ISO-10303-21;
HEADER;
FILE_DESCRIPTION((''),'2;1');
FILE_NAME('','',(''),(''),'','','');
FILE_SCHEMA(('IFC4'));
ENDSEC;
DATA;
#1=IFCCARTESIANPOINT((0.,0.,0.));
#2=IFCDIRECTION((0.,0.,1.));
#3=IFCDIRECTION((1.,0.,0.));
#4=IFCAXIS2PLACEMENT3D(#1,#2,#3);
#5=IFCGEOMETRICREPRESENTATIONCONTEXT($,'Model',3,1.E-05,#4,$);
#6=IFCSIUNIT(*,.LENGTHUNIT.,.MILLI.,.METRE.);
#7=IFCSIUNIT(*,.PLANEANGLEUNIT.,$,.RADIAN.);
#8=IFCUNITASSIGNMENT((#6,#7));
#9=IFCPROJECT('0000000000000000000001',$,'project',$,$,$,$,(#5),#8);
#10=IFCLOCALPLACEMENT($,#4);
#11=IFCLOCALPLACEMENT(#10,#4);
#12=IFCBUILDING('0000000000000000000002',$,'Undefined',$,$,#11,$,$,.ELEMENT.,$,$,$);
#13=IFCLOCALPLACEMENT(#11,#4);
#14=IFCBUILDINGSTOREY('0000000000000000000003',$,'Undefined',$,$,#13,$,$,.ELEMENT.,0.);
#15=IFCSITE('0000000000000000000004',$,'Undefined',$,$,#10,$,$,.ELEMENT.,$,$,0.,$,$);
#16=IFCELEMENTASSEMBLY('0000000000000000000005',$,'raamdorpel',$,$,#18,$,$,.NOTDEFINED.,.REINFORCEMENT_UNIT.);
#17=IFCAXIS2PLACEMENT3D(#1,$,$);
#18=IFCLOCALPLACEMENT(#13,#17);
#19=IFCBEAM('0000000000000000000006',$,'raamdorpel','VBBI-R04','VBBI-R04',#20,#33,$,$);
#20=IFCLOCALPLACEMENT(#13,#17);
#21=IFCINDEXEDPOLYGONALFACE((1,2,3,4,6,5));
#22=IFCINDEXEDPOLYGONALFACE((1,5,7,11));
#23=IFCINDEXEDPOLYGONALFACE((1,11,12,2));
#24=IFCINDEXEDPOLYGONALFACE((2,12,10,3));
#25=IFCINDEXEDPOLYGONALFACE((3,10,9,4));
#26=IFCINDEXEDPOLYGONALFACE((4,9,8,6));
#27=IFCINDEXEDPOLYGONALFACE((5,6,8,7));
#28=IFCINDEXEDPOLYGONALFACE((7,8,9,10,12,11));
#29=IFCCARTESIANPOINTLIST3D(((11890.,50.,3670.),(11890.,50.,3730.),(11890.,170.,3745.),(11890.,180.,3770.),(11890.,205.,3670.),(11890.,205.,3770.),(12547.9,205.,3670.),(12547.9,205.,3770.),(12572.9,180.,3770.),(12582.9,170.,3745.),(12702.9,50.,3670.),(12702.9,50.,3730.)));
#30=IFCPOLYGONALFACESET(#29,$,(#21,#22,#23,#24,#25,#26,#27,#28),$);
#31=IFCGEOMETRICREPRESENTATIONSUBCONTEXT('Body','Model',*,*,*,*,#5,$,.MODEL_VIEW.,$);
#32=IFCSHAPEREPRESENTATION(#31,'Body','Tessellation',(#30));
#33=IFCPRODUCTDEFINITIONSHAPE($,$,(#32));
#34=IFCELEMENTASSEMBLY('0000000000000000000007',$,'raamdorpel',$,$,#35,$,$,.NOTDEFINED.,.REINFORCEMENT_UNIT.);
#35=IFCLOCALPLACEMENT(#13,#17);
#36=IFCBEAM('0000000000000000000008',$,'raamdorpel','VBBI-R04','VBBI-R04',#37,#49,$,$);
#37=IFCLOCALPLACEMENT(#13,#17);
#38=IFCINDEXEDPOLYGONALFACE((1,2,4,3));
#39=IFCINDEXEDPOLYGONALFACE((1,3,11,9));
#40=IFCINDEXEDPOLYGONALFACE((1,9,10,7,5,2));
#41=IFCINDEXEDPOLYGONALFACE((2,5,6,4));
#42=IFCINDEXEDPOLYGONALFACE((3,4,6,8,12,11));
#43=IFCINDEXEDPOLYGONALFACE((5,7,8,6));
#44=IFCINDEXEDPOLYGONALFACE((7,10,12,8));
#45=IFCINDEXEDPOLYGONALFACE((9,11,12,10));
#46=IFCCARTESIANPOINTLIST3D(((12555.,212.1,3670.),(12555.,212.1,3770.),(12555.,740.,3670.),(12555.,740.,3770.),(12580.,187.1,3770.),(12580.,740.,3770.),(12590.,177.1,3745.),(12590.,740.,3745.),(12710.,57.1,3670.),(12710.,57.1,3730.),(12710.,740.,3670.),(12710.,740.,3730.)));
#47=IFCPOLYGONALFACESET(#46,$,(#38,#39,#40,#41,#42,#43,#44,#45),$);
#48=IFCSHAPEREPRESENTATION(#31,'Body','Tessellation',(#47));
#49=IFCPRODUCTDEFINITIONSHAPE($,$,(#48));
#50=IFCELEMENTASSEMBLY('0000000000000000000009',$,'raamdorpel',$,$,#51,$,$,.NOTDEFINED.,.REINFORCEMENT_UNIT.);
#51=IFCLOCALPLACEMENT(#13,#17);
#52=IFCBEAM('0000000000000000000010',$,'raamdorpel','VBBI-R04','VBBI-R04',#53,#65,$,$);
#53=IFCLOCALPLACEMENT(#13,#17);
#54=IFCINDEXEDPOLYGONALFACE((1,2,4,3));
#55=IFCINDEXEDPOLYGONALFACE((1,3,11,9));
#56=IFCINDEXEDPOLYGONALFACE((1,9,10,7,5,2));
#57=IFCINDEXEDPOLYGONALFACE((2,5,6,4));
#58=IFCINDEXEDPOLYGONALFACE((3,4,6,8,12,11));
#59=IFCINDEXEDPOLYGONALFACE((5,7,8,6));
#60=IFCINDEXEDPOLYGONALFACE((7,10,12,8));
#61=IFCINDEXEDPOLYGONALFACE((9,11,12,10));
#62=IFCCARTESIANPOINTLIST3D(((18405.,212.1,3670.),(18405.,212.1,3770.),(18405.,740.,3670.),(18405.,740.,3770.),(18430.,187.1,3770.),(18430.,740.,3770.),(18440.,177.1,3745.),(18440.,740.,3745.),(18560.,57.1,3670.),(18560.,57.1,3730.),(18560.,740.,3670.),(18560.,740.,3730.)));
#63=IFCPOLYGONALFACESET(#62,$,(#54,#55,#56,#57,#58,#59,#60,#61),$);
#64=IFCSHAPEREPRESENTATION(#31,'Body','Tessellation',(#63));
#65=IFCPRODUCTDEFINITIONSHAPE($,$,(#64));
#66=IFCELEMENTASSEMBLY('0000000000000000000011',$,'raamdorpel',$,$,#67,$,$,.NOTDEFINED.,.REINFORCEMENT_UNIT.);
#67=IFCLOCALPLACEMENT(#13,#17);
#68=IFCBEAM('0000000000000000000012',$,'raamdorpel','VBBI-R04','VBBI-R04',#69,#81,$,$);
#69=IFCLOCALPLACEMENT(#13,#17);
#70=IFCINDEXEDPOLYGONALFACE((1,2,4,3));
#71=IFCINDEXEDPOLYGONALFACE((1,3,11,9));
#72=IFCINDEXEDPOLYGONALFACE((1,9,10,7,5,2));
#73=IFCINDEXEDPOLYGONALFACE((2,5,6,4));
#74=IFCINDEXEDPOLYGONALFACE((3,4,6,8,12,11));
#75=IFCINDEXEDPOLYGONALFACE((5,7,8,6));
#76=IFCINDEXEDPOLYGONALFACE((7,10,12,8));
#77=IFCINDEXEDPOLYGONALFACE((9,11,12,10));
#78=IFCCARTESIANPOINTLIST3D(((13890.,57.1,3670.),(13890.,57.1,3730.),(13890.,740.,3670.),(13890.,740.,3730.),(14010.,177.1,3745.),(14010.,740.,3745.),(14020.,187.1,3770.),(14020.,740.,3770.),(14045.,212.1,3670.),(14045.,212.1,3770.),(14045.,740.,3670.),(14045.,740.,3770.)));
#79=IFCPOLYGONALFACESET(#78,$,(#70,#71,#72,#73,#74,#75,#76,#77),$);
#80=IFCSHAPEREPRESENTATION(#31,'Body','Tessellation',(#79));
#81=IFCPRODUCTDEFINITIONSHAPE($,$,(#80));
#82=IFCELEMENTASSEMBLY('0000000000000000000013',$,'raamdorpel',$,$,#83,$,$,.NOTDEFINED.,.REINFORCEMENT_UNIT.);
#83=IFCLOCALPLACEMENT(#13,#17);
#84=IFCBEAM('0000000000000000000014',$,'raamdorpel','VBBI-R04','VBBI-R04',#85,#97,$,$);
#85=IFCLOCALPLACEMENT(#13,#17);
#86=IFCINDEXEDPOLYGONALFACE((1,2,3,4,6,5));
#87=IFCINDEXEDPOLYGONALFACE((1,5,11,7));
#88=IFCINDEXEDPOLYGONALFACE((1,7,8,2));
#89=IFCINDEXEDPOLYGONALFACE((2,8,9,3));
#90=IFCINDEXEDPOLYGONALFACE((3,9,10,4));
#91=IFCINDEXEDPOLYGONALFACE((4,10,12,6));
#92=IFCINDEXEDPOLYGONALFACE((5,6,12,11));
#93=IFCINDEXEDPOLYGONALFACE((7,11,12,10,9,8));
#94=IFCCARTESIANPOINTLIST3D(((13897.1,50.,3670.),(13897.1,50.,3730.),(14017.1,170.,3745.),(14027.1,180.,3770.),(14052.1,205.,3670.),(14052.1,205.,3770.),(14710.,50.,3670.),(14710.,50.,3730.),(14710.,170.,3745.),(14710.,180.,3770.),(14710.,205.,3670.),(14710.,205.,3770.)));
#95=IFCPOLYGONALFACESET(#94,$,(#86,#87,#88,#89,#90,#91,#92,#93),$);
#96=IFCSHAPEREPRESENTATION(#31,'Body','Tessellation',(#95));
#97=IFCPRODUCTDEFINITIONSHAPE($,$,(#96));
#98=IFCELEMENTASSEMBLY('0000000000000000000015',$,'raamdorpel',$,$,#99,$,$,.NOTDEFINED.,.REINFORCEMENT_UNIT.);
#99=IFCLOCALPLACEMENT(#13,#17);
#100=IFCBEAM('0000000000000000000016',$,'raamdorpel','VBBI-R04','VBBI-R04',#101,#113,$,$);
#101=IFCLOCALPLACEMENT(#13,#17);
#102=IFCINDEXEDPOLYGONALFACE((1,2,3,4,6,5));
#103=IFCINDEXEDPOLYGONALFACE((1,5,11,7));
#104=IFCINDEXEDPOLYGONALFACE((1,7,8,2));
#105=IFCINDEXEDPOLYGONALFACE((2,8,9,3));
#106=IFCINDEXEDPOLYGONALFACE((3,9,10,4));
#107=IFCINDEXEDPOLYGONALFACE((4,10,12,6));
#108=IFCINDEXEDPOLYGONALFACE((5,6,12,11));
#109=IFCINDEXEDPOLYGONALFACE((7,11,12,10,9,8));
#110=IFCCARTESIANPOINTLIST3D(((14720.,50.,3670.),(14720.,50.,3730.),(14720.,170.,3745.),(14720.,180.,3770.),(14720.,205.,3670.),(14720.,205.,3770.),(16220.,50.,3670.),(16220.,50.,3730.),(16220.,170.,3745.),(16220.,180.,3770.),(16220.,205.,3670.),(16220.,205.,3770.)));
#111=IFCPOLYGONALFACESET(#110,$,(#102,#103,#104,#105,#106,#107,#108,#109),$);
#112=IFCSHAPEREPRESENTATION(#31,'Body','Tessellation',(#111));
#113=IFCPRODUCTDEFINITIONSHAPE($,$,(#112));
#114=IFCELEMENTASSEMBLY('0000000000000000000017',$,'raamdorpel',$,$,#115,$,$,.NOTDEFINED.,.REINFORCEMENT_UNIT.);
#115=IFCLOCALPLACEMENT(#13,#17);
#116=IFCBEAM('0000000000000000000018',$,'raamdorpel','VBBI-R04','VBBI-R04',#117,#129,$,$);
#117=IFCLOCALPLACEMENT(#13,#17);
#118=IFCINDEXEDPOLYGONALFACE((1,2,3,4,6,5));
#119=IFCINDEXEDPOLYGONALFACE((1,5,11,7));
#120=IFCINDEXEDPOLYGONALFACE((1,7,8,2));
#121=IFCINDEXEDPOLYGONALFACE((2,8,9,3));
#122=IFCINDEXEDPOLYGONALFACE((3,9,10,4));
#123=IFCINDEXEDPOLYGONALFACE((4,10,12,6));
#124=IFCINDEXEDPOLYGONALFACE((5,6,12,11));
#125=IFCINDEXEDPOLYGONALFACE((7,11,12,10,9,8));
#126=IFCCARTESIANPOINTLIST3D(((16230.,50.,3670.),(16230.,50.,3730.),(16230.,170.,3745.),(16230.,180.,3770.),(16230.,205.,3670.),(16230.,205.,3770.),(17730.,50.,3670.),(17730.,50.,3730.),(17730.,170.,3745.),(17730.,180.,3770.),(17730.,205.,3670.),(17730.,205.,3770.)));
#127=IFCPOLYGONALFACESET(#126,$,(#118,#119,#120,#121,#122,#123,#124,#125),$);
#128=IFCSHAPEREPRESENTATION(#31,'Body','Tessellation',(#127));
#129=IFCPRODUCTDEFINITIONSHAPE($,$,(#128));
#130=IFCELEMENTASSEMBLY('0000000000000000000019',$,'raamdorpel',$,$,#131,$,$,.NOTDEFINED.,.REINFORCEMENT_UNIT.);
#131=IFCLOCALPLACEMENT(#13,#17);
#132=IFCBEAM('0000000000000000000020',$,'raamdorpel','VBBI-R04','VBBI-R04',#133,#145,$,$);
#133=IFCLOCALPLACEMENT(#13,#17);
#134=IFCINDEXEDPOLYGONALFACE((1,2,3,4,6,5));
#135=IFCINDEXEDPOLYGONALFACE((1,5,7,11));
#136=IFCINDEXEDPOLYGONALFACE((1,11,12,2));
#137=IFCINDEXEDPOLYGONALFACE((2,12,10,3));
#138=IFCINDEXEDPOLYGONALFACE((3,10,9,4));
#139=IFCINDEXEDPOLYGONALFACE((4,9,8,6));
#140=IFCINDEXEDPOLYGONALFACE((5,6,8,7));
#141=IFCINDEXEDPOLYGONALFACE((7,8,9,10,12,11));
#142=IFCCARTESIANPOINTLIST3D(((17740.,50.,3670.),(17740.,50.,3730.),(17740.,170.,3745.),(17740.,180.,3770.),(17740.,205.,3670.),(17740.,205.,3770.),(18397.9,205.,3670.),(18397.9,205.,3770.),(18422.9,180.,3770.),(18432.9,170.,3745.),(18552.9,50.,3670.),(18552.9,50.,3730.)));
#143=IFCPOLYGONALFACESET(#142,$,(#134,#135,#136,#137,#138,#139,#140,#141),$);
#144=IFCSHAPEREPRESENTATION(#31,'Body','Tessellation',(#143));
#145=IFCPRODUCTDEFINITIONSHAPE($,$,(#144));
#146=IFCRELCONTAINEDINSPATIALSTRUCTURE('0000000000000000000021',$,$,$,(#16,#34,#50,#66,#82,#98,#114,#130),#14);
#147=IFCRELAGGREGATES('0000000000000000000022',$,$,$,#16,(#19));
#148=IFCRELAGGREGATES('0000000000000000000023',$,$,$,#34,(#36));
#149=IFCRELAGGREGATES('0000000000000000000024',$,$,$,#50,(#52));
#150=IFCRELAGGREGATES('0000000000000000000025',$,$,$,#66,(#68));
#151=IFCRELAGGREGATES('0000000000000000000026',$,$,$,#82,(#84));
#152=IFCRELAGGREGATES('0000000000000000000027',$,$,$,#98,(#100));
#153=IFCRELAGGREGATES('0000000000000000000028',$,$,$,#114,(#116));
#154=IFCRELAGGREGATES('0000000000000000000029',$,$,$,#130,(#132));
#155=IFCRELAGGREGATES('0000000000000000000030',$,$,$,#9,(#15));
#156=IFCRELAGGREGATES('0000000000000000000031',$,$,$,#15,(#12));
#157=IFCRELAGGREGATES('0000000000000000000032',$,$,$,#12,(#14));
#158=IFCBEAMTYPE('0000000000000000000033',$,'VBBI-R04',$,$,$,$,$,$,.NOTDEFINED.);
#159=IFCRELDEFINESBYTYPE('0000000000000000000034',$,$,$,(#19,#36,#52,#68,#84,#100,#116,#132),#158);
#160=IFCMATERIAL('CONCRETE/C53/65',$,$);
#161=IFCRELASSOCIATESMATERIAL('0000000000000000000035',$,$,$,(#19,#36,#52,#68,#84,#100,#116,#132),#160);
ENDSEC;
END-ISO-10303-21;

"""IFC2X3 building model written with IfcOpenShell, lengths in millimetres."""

from ifc_helpers import new_model, si_unit, frame, origin_with_axes, place, context, subcontext, project, spatial, polyline, outline, extrude, clip, halfspace, material, type_object, element, aggregate, save


model = new_model("IFC2X3")

# Units and contexts
model_context = context("Model", 3, precision=1e-05, world=origin_with_axes())
body_context = subcontext(model_context, "Body", "Model", "MODEL_VIEW")
ifc_project = project(units=[si_unit("LENGTHUNIT", "METRE", prefix="MILLI"), si_unit("PLANEANGLEUNIT", "RADIAN")], contexts=[model_context])

# Site, building, storey
site_placement = place(None, origin_with_axes())
site = spatial("IfcSite", under=ifc_project, at=site_placement, Name="Undefined", CompositionType="ELEMENT", RefElevation=0.0)
building_placement = place(site_placement, origin_with_axes())
building = spatial("IfcBuilding", under=site, at=building_placement, Name="Undefined", CompositionType="ELEMENT")
storey_placement = place(building_placement, origin_with_axes())
storey = spatial("IfcBuildingStorey", under=building, at=storey_placement, Name="Undefined", CompositionType="ELEMENT", Elevation=0.0)

# Element assemblies, beams
ifc_material = material(Name="CONCRETE/C53/65")
beam_type_1 = type_object("IfcBeamType", Name="VBBI-R04", PredefinedType="NOTDEFINED")
assembly_1_placement = place(storey_placement, origin_with_axes())
assembly_1 = element("IfcElementAssembly", 1, at=assembly_1_placement, inside=storey, Name="raamdorpel", AssemblyPlace="NOTDEFINED", PredefinedType="REINFORCEMENT_UNIT")
beam_1_placement = place(assembly_1_placement, frame((11890.0, 127.5, 3720.0), z_axis=(-0.000001, -1.0, 0.0), x_axis=(1.0, -0.000001, 0.0)))
beam_1 = element("IfcBeam", 2, at=beam_1_placement, type_object=beam_type_1, material=ifc_material, Name="raamdorpel", Description="VBBI-R04", ObjectType="VBBI-R04", context=body_context, shape_type="Clipping", body=[
    clip(extrude(outline(polyline([(50.0, -77.5), (-50.0, -77.5), (-50.0, -52.5), (-25.0, -42.5), (-10.0, 77.5), (50.0, 77.5), (50.0, -77.5)])), frame((813.7, 0.0, 0.0), z_axis=(-1.0, 0.0, 0.0), x_axis=(0.0, -1.0, 0.0)), (0.0, 0.0, 1.0), 813.7), halfspace(frame((816.5, 0.0, 81.0), z_axis=(0.707107, 0.0, -0.707107), x_axis=(0.0, 1.0, 0.0)), False)),
])
aggregate(assembly_1, [beam_1])
assembly_2_placement = place(storey_placement, origin_with_axes())
assembly_2 = element("IfcElementAssembly", 3, at=assembly_2_placement, inside=storey, Name="raamdorpel", AssemblyPlace="NOTDEFINED", PredefinedType="REINFORCEMENT_UNIT")
beam_2_placement = place(assembly_2_placement, frame((12632.5, 50.0, 3720.0), z_axis=(1.0, -0.000002, 0.0), x_axis=(0.000002, 1.0, 0.0)))
beam_2 = element("IfcBeam", 4, at=beam_2_placement, type_object=beam_type_1, material=ifc_material, Name="raamdorpel", Description="VBBI-R04", ObjectType="VBBI-R04", context=body_context, shape_type="Clipping", body=[
    clip(extrude(outline(polyline([(50.0, -77.5), (-50.0, -77.5), (-50.0, -52.5), (-25.0, -42.5), (-10.0, 77.5), (50.0, 77.5), (50.0, -77.5)])), frame((690.0, 0.0, 0.0), z_axis=(-1.0, 0.0, 0.0), x_axis=(0.0, -1.0, 0.0)), (0.0, 0.0, 1.0), 683.7), halfspace(frame((3.5, 0.0, 81.0), z_axis=(0.707107, 0.0, 0.707107), x_axis=(0.0, 1.0, 0.0)), True)),
])
aggregate(assembly_2, [beam_2])
assembly_3_placement = place(storey_placement, origin_with_axes())
assembly_3 = element("IfcElementAssembly", 5, at=assembly_3_placement, inside=storey, Name="raamdorpel", AssemblyPlace="NOTDEFINED", PredefinedType="REINFORCEMENT_UNIT")
beam_3_placement = place(assembly_3_placement, frame((18482.5, 50.0, 3720.0), z_axis=(1.0, 0.0, 0.0), x_axis=(0.0, 1.0, 0.0)))
beam_3 = element("IfcBeam", 6, at=beam_3_placement, type_object=beam_type_1, material=ifc_material, Name="raamdorpel", Description="VBBI-R04", ObjectType="VBBI-R04", context=body_context, shape_type="Clipping", body=[
    clip(extrude(outline(polyline([(50.0, -77.5), (-50.0, -77.5), (-50.0, -52.5), (-25.0, -42.5), (-10.0, 77.5), (50.0, 77.5), (50.0, -77.5)])), frame((690.0, 0.0, 0.0), z_axis=(-1.0, 0.0, 0.0), x_axis=(0.0, -1.0, 0.0)), (0.0, 0.0, 1.0), 683.7), halfspace(frame((3.5, 0.0, 81.0), z_axis=(0.707107, 0.0, 0.707107), x_axis=(0.0, 1.0, 0.0)), True)),
])
aggregate(assembly_3, [beam_3])
assembly_4_placement = place(storey_placement, origin_with_axes())
assembly_4 = element("IfcElementAssembly", 7, at=assembly_4_placement, inside=storey, Name="raamdorpel", AssemblyPlace="NOTDEFINED", PredefinedType="REINFORCEMENT_UNIT")
beam_4_placement = place(assembly_4_placement, frame((13967.5, 740.0, 3720.0), z_axis=(-1.0, 0.0, 0.0), x_axis=(0.0, -1.0, 0.0)))
beam_4 = element("IfcBeam", 8, at=beam_4_placement, type_object=beam_type_1, material=ifc_material, Name="raamdorpel", Description="VBBI-R04", ObjectType="VBBI-R04", context=body_context, shape_type="Clipping", body=[
    clip(extrude(outline(polyline([(50.0, -77.5), (-50.0, -77.5), (-50.0, -52.5), (-25.0, -42.5), (-10.0, 77.5), (50.0, 77.5), (50.0, -77.5)])), frame((683.7, 0.0, 0.0), z_axis=(-1.0, 0.0, 0.0), x_axis=(0.0, -1.0, 0.0)), (0.0, 0.0, 1.0), 683.7), halfspace(frame((686.5, 0.0, 81.0), z_axis=(0.707107, 0.0, -0.707107), x_axis=(0.0, 1.0, 0.0)), False)),
])
aggregate(assembly_4, [beam_4])
assembly_5_placement = place(storey_placement, origin_with_axes())
assembly_5 = element("IfcElementAssembly", 9, at=assembly_5_placement, inside=storey, Name="raamdorpel", AssemblyPlace="NOTDEFINED", PredefinedType="REINFORCEMENT_UNIT")
beam_5_placement = place(assembly_5_placement, frame((13890.0, 127.5, 3720.0), z_axis=(0.0, -1.0, 0.0), x_axis=(1.0, 0.0, 0.0)))
beam_5 = element("IfcBeam", 10, at=beam_5_placement, type_object=beam_type_1, material=ifc_material, Name="raamdorpel", Description="VBBI-R04", ObjectType="VBBI-R04", context=body_context, shape_type="Clipping", body=[
    clip(extrude(outline(polyline([(50.0, -77.5), (-50.0, -77.5), (-50.0, -52.5), (-25.0, -42.5), (-10.0, 77.5), (50.0, 77.5), (50.0, -77.5)])), frame((820.0, 0.0, 0.0), z_axis=(-1.0, 0.0, 0.0), x_axis=(0.0, -1.0, 0.0)), (0.0, 0.0, 1.0), 813.7), halfspace(frame((3.5, 0.0, 81.0), z_axis=(0.707107, 0.0, 0.707107), x_axis=(0.0, 1.0, 0.0)), True)),
])
aggregate(assembly_5, [beam_5])
assembly_6_placement = place(storey_placement, origin_with_axes())
assembly_6 = element("IfcElementAssembly", 11, at=assembly_6_placement, inside=storey, Name="raamdorpel", AssemblyPlace="NOTDEFINED", PredefinedType="REINFORCEMENT_UNIT")
beam_6_placement = place(assembly_6_placement, frame((14720.0, 127.5, 3720.0), z_axis=(0.0, -1.0, 0.0), x_axis=(1.0, 0.0, 0.0)))
beam_6 = element("IfcBeam", 12, at=beam_6_placement, type_object=beam_type_1, material=ifc_material, Name="raamdorpel", Description="VBBI-R04", ObjectType="VBBI-R04", context=body_context, shape_type="SweptSolid", body=[
    extrude(outline(polyline([(50.0, -77.5), (-50.0, -77.5), (-50.0, -52.5), (-25.0, -42.5), (-10.0, 77.5), (50.0, 77.5), (50.0, -77.5)])), frame((1500.0, 0.0, 0.0), z_axis=(-1.0, 0.0, 0.0), x_axis=(0.0, -1.0, 0.0)), (0.0, 0.0, 1.0), 1500.0),
])
aggregate(assembly_6, [beam_6])
assembly_7_placement = place(storey_placement, origin_with_axes())
assembly_7 = element("IfcElementAssembly", 13, at=assembly_7_placement, inside=storey, Name="raamdorpel", AssemblyPlace="NOTDEFINED", PredefinedType="REINFORCEMENT_UNIT")
beam_7_placement = place(assembly_7_placement, frame((16230.0, 127.5, 3720.0), z_axis=(0.0, -1.0, 0.0), x_axis=(1.0, 0.0, 0.0)))
beam_7 = element("IfcBeam", 14, at=beam_7_placement, type_object=beam_type_1, material=ifc_material, Name="raamdorpel", Description="VBBI-R04", ObjectType="VBBI-R04", context=body_context, shape_type="SweptSolid", body=[
    extrude(outline(polyline([(50.0, -77.5), (-50.0, -77.5), (-50.0, -52.5), (-25.0, -42.5), (-10.0, 77.5), (50.0, 77.5), (50.0, -77.5)])), frame((1500.0, 0.0, 0.0), z_axis=(-1.0, 0.0, 0.0), x_axis=(0.0, -1.0, 0.0)), (0.0, 0.0, 1.0), 1500.0),
])
aggregate(assembly_7, [beam_7])
assembly_8_placement = place(storey_placement, origin_with_axes())
assembly_8 = element("IfcElementAssembly", 15, at=assembly_8_placement, inside=storey, Name="raamdorpel", AssemblyPlace="NOTDEFINED", PredefinedType="REINFORCEMENT_UNIT")
beam_8_placement = place(assembly_8_placement, frame((17740.0, 127.5, 3720.0), z_axis=(-0.000001, -1.0, 0.0), x_axis=(1.0, -0.000001, 0.0)))
beam_8 = element("IfcBeam", 16, at=beam_8_placement, type_object=beam_type_1, material=ifc_material, Name="raamdorpel", Description="VBBI-R04", ObjectType="VBBI-R04", context=body_context, shape_type="Clipping", body=[
    clip(extrude(outline(polyline([(50.0, -77.5), (-50.0, -77.5), (-50.0, -52.5), (-25.0, -42.5), (-10.0, 77.5), (50.0, 77.5), (50.0, -77.5)])), frame((813.7, 0.0, 0.0), z_axis=(-1.0, 0.0, 0.0), x_axis=(0.0, -1.0, 0.0)), (0.0, 0.0, 1.0), 813.7), halfspace(frame((816.5, 0.0, 81.0), z_axis=(0.707106, 0.0, -0.707107), x_axis=(0.0, 1.0, 0.0)), False)),
])
aggregate(assembly_8, [beam_8])

save(model, "model.ifc")
